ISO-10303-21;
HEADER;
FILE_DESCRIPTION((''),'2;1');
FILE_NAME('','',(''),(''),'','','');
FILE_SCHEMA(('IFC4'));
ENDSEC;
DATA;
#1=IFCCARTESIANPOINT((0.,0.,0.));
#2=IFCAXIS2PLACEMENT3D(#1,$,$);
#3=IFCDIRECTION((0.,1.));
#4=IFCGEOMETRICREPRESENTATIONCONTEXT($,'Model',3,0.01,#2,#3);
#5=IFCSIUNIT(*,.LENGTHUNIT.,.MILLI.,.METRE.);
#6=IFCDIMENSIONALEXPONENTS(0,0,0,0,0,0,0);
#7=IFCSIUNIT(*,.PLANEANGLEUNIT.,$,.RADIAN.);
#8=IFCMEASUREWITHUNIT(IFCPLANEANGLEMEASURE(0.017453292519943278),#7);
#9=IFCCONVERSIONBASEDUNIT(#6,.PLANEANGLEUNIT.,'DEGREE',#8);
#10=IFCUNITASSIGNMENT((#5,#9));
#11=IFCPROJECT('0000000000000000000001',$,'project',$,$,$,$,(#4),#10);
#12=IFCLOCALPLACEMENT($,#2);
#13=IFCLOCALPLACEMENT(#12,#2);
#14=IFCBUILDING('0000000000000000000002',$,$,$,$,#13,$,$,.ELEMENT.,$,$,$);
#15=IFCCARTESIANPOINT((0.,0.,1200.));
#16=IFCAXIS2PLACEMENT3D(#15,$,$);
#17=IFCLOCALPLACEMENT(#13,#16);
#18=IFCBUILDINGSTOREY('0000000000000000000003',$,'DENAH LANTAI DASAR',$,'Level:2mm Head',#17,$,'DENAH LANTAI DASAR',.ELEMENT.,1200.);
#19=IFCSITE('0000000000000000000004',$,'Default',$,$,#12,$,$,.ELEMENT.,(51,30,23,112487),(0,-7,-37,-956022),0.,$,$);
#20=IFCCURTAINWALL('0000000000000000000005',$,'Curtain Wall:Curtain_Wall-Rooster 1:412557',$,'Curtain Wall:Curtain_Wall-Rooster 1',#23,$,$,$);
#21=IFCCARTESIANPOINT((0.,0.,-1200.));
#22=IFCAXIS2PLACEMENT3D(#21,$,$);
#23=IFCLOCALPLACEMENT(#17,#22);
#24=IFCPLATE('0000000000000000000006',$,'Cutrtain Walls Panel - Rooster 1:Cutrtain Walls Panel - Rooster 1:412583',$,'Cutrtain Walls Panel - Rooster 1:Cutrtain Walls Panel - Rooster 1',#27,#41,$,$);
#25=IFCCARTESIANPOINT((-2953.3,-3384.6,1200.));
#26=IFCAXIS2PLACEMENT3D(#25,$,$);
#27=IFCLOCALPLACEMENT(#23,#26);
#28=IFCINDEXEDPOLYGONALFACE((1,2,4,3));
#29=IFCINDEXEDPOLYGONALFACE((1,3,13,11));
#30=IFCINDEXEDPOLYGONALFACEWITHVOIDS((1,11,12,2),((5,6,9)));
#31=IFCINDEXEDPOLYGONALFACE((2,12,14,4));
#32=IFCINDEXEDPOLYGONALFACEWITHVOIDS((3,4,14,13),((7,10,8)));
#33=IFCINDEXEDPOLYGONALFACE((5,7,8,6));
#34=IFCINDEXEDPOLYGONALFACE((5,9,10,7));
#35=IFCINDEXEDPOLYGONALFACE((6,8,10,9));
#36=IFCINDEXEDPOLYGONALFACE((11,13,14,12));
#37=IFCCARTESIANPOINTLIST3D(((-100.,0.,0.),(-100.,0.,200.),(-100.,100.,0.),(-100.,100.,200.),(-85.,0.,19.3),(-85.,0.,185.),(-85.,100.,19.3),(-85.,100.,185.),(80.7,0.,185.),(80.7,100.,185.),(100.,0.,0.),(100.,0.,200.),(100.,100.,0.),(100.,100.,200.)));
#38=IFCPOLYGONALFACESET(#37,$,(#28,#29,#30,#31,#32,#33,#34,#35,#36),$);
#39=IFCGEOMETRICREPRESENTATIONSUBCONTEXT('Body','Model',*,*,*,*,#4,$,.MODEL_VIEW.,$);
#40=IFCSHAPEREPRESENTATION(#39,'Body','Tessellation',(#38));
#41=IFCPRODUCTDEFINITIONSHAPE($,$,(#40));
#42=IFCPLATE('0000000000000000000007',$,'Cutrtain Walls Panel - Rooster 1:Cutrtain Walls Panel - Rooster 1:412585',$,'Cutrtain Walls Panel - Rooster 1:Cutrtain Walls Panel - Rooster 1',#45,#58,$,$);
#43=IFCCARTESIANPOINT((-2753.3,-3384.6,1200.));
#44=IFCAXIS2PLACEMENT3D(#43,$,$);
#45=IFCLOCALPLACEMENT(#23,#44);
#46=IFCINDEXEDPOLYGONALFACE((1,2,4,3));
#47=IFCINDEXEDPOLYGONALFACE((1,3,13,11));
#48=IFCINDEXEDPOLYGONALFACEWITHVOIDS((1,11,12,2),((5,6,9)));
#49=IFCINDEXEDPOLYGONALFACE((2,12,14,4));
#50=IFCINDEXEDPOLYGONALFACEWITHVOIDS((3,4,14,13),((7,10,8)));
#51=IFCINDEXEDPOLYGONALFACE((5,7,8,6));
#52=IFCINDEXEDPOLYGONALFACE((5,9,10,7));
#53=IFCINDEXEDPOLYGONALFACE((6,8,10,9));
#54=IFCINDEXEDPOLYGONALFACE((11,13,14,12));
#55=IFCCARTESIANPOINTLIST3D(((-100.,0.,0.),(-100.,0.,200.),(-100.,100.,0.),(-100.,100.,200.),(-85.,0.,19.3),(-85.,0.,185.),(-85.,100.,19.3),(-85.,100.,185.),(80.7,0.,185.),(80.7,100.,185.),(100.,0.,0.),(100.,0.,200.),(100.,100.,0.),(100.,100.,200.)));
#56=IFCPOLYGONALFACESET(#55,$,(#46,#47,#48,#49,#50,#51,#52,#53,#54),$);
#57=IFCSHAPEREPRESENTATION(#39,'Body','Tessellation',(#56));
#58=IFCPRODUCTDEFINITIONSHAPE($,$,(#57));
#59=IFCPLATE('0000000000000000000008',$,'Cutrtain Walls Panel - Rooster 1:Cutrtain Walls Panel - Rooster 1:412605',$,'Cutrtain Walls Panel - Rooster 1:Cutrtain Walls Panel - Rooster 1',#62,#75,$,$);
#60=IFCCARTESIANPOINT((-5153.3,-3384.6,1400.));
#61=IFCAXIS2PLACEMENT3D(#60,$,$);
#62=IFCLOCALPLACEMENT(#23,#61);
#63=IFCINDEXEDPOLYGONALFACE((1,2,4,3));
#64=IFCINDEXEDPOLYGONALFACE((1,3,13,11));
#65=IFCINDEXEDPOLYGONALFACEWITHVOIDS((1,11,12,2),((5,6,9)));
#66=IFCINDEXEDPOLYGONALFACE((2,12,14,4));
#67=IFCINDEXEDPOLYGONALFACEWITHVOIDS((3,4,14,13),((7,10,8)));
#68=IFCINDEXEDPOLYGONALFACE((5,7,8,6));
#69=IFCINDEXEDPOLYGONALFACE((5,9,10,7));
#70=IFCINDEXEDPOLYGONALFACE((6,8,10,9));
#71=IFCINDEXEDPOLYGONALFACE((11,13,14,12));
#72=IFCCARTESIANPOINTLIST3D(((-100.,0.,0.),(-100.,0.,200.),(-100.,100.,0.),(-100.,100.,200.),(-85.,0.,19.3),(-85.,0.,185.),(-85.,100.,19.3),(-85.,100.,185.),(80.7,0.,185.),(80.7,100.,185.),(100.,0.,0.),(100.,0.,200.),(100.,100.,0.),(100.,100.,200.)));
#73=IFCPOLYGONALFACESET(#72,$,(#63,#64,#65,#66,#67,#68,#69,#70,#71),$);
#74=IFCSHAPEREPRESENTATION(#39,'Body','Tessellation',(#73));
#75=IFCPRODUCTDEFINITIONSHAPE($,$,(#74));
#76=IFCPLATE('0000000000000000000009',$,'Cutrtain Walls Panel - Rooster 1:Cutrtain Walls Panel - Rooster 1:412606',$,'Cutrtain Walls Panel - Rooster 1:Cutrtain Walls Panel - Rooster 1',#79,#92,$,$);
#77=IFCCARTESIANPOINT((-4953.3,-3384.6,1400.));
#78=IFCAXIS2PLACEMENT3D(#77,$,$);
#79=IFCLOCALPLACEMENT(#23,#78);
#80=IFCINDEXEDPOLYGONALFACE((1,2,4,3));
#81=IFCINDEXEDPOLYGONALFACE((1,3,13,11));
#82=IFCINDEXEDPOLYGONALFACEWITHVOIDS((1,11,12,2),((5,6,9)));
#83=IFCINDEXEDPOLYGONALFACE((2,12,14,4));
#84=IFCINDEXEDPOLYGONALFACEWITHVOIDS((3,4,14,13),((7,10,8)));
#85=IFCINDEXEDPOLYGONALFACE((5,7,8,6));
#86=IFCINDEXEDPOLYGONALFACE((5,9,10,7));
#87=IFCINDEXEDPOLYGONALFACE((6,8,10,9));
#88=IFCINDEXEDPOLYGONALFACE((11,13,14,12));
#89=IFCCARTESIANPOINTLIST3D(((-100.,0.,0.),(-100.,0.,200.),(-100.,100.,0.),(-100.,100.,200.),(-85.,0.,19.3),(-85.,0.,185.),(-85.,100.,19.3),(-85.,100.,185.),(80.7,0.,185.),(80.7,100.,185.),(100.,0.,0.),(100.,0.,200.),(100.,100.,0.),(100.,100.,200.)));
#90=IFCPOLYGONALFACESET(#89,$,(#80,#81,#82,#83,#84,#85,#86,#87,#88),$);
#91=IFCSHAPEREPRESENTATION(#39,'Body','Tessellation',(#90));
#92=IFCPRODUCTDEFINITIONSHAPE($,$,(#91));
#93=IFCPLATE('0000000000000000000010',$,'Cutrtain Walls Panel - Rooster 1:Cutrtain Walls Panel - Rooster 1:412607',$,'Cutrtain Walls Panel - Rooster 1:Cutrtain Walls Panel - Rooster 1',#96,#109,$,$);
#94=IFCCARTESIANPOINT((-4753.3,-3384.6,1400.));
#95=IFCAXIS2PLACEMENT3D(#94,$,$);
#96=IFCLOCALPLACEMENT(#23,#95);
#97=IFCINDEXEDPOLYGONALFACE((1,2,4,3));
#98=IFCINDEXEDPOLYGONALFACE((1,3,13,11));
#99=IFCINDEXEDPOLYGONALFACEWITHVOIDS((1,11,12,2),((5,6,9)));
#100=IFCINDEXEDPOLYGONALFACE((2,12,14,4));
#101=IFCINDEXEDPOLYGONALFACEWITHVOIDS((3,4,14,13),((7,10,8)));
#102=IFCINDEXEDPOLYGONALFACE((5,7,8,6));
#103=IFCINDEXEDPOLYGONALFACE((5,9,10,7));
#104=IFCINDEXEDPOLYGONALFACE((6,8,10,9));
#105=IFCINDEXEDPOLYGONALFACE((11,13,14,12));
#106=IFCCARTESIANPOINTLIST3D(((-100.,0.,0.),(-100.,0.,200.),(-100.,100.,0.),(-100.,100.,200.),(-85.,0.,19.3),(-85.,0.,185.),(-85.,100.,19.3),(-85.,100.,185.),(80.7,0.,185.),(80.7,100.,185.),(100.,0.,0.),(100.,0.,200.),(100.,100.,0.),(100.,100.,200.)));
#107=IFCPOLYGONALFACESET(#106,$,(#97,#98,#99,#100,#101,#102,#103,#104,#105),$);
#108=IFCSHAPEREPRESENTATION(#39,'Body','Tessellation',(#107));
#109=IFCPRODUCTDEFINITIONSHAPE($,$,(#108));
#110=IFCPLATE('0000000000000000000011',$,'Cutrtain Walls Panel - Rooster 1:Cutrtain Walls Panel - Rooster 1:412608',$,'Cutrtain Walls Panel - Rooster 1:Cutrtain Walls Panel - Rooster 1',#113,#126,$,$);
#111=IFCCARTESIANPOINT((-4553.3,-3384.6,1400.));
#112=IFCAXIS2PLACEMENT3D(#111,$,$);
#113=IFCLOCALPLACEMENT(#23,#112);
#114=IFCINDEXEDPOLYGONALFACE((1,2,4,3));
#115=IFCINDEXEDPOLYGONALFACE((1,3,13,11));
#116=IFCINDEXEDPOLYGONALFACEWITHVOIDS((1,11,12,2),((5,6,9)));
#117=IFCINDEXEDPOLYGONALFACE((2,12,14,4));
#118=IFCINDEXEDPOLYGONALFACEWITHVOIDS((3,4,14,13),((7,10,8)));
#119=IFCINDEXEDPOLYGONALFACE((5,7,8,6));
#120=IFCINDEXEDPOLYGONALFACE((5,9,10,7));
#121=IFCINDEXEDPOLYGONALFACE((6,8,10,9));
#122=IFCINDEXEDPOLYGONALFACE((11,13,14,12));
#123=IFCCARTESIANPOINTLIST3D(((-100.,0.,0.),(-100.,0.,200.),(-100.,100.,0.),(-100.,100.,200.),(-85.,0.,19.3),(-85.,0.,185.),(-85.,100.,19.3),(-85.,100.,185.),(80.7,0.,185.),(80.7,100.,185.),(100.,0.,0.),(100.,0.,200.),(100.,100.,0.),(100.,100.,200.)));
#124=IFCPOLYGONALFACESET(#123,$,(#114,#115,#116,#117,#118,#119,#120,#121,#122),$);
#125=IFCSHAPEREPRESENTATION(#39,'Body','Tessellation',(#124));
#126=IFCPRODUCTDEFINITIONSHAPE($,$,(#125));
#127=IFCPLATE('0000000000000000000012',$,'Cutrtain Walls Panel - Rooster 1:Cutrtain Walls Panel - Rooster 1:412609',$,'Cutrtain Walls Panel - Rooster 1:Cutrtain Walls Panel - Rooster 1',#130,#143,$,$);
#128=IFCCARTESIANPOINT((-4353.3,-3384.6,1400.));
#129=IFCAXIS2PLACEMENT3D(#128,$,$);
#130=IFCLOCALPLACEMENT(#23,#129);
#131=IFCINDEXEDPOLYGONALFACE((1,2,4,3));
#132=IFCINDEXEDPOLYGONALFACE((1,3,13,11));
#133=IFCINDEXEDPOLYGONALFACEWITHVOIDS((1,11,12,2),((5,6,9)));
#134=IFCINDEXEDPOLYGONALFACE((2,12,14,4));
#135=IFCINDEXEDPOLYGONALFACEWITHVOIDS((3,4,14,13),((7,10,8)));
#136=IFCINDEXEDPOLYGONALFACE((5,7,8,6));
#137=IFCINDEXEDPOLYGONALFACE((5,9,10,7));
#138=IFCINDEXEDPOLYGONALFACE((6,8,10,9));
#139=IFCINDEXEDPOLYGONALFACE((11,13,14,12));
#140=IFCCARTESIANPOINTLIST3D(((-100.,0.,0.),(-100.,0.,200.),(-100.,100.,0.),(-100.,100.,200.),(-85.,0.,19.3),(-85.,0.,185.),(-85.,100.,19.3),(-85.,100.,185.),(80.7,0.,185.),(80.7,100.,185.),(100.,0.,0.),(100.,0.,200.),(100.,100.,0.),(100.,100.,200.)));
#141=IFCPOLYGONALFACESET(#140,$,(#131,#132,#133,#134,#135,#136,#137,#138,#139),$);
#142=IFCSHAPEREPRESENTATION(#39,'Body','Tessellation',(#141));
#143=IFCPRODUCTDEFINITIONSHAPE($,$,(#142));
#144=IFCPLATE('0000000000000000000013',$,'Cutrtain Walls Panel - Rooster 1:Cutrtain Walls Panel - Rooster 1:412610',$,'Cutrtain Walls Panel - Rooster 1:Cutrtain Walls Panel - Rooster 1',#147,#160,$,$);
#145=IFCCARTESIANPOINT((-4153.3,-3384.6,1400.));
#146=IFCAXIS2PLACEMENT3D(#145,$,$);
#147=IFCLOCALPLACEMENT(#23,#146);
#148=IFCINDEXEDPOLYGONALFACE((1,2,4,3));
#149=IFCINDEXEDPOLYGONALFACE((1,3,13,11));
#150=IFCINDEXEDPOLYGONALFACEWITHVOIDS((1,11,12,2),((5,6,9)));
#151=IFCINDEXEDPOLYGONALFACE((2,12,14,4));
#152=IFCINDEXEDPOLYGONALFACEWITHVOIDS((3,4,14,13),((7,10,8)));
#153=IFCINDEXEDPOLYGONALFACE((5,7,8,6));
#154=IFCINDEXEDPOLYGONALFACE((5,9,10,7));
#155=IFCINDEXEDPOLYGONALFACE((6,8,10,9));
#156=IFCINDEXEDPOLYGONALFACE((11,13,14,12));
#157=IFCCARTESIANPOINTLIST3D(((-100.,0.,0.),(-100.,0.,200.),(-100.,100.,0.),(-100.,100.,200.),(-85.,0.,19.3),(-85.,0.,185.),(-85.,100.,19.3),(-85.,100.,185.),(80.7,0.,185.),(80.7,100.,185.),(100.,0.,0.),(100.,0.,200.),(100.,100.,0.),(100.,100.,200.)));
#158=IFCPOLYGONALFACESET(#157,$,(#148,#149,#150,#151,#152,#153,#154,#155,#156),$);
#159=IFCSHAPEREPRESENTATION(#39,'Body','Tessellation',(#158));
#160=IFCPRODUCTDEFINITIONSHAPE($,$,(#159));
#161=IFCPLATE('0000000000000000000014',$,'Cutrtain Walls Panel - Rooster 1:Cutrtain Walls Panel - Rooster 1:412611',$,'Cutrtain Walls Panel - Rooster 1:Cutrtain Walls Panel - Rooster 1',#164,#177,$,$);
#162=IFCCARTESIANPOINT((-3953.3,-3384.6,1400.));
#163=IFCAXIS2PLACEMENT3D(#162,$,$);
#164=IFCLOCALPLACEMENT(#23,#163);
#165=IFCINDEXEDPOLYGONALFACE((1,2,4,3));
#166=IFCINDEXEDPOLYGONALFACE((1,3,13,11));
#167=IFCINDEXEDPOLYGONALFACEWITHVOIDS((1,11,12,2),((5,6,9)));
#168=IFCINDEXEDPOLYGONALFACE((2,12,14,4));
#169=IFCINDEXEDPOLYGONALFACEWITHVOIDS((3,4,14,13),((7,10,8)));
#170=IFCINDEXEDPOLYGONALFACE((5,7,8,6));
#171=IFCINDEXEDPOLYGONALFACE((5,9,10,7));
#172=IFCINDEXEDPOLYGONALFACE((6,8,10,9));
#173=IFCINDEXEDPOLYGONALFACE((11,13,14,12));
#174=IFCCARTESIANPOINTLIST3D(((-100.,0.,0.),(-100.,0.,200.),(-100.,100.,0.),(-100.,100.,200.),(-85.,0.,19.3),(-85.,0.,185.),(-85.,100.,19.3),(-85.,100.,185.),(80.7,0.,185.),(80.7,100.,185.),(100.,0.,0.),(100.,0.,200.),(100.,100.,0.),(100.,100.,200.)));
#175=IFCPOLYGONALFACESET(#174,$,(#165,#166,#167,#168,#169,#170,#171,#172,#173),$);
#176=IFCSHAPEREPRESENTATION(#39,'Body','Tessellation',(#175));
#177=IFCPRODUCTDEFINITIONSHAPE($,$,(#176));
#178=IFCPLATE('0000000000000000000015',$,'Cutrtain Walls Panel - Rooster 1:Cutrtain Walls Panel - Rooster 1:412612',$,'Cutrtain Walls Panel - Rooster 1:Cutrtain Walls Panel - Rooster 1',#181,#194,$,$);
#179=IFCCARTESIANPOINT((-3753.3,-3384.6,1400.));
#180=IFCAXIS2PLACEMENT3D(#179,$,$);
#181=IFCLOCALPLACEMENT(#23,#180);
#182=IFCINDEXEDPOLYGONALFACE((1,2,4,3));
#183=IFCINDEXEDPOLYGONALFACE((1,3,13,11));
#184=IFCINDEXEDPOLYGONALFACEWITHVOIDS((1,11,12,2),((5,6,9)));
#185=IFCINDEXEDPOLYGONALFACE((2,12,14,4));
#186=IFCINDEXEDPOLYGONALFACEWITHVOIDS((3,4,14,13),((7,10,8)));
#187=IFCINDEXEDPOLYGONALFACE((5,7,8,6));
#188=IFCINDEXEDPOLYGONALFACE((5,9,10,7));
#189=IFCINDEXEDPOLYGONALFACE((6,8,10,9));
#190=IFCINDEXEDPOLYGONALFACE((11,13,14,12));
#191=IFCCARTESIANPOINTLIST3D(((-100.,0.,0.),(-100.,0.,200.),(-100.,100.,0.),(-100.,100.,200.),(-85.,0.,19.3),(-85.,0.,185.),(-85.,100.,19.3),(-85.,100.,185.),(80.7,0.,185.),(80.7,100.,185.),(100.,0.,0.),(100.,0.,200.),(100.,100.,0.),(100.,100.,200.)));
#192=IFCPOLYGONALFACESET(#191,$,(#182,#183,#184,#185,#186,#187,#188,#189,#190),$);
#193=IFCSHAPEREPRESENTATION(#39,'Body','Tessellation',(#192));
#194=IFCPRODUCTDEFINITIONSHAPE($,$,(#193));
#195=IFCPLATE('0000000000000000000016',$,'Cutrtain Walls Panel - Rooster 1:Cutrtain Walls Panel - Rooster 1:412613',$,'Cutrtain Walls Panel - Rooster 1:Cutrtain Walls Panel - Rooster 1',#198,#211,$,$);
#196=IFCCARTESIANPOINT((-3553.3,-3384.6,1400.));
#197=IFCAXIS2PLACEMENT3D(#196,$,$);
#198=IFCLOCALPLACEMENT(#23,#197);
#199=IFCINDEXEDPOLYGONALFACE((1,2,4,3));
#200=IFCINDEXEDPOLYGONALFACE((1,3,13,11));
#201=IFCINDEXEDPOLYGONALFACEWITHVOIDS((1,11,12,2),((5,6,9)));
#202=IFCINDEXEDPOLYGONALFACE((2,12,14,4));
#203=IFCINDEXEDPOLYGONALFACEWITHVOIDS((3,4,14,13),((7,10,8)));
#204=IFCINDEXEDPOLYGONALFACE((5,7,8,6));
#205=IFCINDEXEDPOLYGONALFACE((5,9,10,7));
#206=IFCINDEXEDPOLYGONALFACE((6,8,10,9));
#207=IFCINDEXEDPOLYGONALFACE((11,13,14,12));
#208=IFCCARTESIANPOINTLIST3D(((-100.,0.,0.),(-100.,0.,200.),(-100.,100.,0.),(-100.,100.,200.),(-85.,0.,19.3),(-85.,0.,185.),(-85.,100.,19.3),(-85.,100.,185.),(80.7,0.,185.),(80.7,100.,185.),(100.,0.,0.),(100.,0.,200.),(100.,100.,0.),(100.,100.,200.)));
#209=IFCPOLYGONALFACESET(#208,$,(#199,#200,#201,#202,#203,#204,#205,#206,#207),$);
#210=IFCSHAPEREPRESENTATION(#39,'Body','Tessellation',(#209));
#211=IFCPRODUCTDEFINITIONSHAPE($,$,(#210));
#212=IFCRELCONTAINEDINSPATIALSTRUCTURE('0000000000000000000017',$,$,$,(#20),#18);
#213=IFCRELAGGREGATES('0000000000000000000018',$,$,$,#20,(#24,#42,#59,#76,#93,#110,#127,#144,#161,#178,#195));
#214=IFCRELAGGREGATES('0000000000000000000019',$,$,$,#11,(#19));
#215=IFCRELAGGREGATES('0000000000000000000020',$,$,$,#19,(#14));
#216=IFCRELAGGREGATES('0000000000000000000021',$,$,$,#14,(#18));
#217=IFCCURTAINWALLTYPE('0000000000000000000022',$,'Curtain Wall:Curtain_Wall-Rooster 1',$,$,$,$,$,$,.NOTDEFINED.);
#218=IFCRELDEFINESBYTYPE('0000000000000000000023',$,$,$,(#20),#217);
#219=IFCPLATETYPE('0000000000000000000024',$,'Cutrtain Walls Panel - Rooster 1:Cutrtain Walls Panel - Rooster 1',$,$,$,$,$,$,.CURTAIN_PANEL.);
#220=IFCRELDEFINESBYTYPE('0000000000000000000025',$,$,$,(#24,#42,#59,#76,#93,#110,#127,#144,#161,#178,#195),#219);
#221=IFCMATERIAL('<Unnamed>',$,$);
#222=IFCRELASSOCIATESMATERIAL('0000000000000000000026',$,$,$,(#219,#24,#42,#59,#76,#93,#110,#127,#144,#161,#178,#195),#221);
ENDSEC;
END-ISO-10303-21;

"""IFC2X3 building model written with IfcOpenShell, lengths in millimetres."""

from ifc_helpers import new_model, entity, si_unit, converted_unit, direction, frame, origin, place, context, subcontext, project, spatial, polyline, outline, extrude, source, transform, mapped, material, type_object, type_shapes, element, aggregate, save


model = new_model("IFC2X3")

# Units and contexts
model_context = context("Model", 3, precision=0.01, world=origin(), true_north=direction((0.0, 1.0)))
body_context = subcontext(model_context, "Body", "Model", "MODEL_VIEW")
ifc_project = project(units=[si_unit("LENGTHUNIT", "METRE", prefix="MILLI"), converted_unit("PLANEANGLEUNIT", "DEGREE", entity("IfcPlaneAngleMeasure", 0.017453292519943278), si_unit("PLANEANGLEUNIT", "RADIAN"), dimensions=[0, 0, 0, 0, 0, 0, 0])], contexts=[model_context])

# Site, building, storey
site_placement = place(None, origin())
site = spatial("IfcSite", under=ifc_project, at=site_placement, Name="Default", CompositionType="ELEMENT", RefLatitude=(51, 30, 23, 112487), RefLongitude=(0, -7, -37, -956022), RefElevation=0.0)
building_placement = place(site_placement, origin())
building = spatial("IfcBuilding", under=site, at=building_placement, CompositionType="ELEMENT")
storey_placement = place(building_placement, frame((0.0, 0.0, 1200.0)))
storey = spatial("IfcBuildingStorey", under=building, at=storey_placement, Name="DENAH LANTAI DASAR", ObjectType="Level:2mm Head", LongName="DENAH LANTAI DASAR", CompositionType="ELEMENT", Elevation=1200.0)

# Curtain wall, plates
curtain_wall_type = type_object("IfcCurtainWallType", Name="Curtain Wall:Curtain_Wall-Rooster 1", PredefinedType="NOTDEFINED")
curtain_wall_placement = place(storey_placement, frame((0.0, 0.0, -1200.0)))
curtain_wall = element("IfcCurtainWall", 1, at=curtain_wall_placement, inside=storey, type_object=curtain_wall_type, Name="Curtain Wall:Curtain_Wall-Rooster 1:412557", ObjectType="Curtain Wall:Curtain_Wall-Rooster 1")
ifc_material = material(Name="<Unnamed>")
plate_type = type_object("IfcPlateType", Name="Cutrtain Walls Panel - Rooster 1:Cutrtain Walls Panel - Rooster 1", PredefinedType="CURTAIN_PANEL", material=ifc_material)
shared_shape = source(origin(), body_context, "Body", "SweptSolid", [
    extrude(outline(polyline([(-100.0, -100.0), (100.0, -100.0), (100.0, 100.0), (-100.0, 100.0), (-100.0, -100.0)]), holes=[polyline([(80.7, 85.0), (-85.0, -80.7), (-85.0, 85.0), (80.7, 85.0)])]), frame((0.0, 0.0, 100.0), z_axis=(0.0, 1.0, 0.0), x_axis=(0.0, 0.0, -1.0)), (0.0, 0.0, 1.0), 100.0),
])
type_shapes(plate_type, [shared_shape])
plate_1_placement = place(curtain_wall_placement, frame((-2953.3, -3384.6, 1200.0)))
plate_1 = element("IfcPlate", 2, at=plate_1_placement, type_object=plate_type, material=ifc_material, Name="Cutrtain Walls Panel - Rooster 1:Cutrtain Walls Panel - Rooster 1:412583", ObjectType="Cutrtain Walls Panel - Rooster 1:Cutrtain Walls Panel - Rooster 1", context=body_context, shape_type="MappedRepresentation", body=[
    mapped(shared_shape, transform((0.0, 0.0, 0.0), scale=1.0)),
])
plate_2_placement = place(curtain_wall_placement, frame((-2753.3, -3384.6, 1200.0)))
plate_2 = element("IfcPlate", 3, at=plate_2_placement, type_object=plate_type, material=ifc_material, Name="Cutrtain Walls Panel - Rooster 1:Cutrtain Walls Panel - Rooster 1:412585", ObjectType="Cutrtain Walls Panel - Rooster 1:Cutrtain Walls Panel - Rooster 1", context=body_context, shape_type="MappedRepresentation", body=[
    mapped(shared_shape, transform((0.0, 0.0, 0.0), scale=1.0)),
])
plate_3_placement = place(curtain_wall_placement, frame((-5153.3, -3384.6, 1400.0)))
plate_3 = element("IfcPlate", 4, at=plate_3_placement, type_object=plate_type, material=ifc_material, Name="Cutrtain Walls Panel - Rooster 1:Cutrtain Walls Panel - Rooster 1:412605", ObjectType="Cutrtain Walls Panel - Rooster 1:Cutrtain Walls Panel - Rooster 1", context=body_context, shape_type="MappedRepresentation", body=[
    mapped(shared_shape, transform((0.0, 0.0, 0.0), scale=1.0)),
])
plate_4_placement = place(curtain_wall_placement, frame((-4953.3, -3384.6, 1400.0)))
plate_4 = element("IfcPlate", 5, at=plate_4_placement, type_object=plate_type, material=ifc_material, Name="Cutrtain Walls Panel - Rooster 1:Cutrtain Walls Panel - Rooster 1:412606", ObjectType="Cutrtain Walls Panel - Rooster 1:Cutrtain Walls Panel - Rooster 1", context=body_context, shape_type="MappedRepresentation", body=[
    mapped(shared_shape, transform((0.0, 0.0, 0.0), scale=1.0)),
])
plate_5_placement = place(curtain_wall_placement, frame((-4753.3, -3384.6, 1400.0)))
plate_5 = element("IfcPlate", 6, at=plate_5_placement, type_object=plate_type, material=ifc_material, Name="Cutrtain Walls Panel - Rooster 1:Cutrtain Walls Panel - Rooster 1:412607", ObjectType="Cutrtain Walls Panel - Rooster 1:Cutrtain Walls Panel - Rooster 1", context=body_context, shape_type="MappedRepresentation", body=[
    mapped(shared_shape, transform((0.0, 0.0, 0.0), scale=1.0)),
])
plate_6_placement = place(curtain_wall_placement, frame((-4553.3, -3384.6, 1400.0)))
plate_6 = element("IfcPlate", 7, at=plate_6_placement, type_object=plate_type, material=ifc_material, Name="Cutrtain Walls Panel - Rooster 1:Cutrtain Walls Panel - Rooster 1:412608", ObjectType="Cutrtain Walls Panel - Rooster 1:Cutrtain Walls Panel - Rooster 1", context=body_context, shape_type="MappedRepresentation", body=[
    mapped(shared_shape, transform((0.0, 0.0, 0.0), scale=1.0)),
])
plate_7_placement = place(curtain_wall_placement, frame((-4353.3, -3384.6, 1400.0)))
plate_7 = element("IfcPlate", 8, at=plate_7_placement, type_object=plate_type, material=ifc_material, Name="Cutrtain Walls Panel - Rooster 1:Cutrtain Walls Panel - Rooster 1:412609", ObjectType="Cutrtain Walls Panel - Rooster 1:Cutrtain Walls Panel - Rooster 1", context=body_context, shape_type="MappedRepresentation", body=[
    mapped(shared_shape, transform((0.0, 0.0, 0.0), scale=1.0)),
])
plate_8_placement = place(curtain_wall_placement, frame((-4153.3, -3384.6, 1400.0)))
plate_8 = element("IfcPlate", 9, at=plate_8_placement, type_object=plate_type, material=ifc_material, Name="Cutrtain Walls Panel - Rooster 1:Cutrtain Walls Panel - Rooster 1:412610", ObjectType="Cutrtain Walls Panel - Rooster 1:Cutrtain Walls Panel - Rooster 1", context=body_context, shape_type="MappedRepresentation", body=[
    mapped(shared_shape, transform((0.0, 0.0, 0.0), scale=1.0)),
])
plate_9_placement = place(curtain_wall_placement, frame((-3953.3, -3384.6, 1400.0)))
plate_9 = element("IfcPlate", 10, at=plate_9_placement, type_object=plate_type, material=ifc_material, Name="Cutrtain Walls Panel - Rooster 1:Cutrtain Walls Panel - Rooster 1:412611", ObjectType="Cutrtain Walls Panel - Rooster 1:Cutrtain Walls Panel - Rooster 1", context=body_context, shape_type="MappedRepresentation", body=[
    mapped(shared_shape, transform((0.0, 0.0, 0.0), scale=1.0)),
])
plate_10_placement = place(curtain_wall_placement, frame((-3753.3, -3384.6, 1400.0)))
plate_10 = element("IfcPlate", 11, at=plate_10_placement, type_object=plate_type, material=ifc_material, Name="Cutrtain Walls Panel - Rooster 1:Cutrtain Walls Panel - Rooster 1:412612", ObjectType="Cutrtain Walls Panel - Rooster 1:Cutrtain Walls Panel - Rooster 1", context=body_context, shape_type="MappedRepresentation", body=[
    mapped(shared_shape, transform((0.0, 0.0, 0.0), scale=1.0)),
])
plate_11_placement = place(curtain_wall_placement, frame((-3553.3, -3384.6, 1400.0)))
plate_11 = element("IfcPlate", 12, at=plate_11_placement, type_object=plate_type, material=ifc_material, Name="Cutrtain Walls Panel - Rooster 1:Cutrtain Walls Panel - Rooster 1:412613", ObjectType="Cutrtain Walls Panel - Rooster 1:Cutrtain Walls Panel - Rooster 1", context=body_context, shape_type="MappedRepresentation", body=[
    mapped(shared_shape, transform((0.0, 0.0, 0.0), scale=1.0)),
])
aggregate(curtain_wall, [plate_1, plate_2, plate_3, plate_4, plate_5, plate_6, plate_7, plate_8, plate_9, plate_10, plate_11])

save(model, "model.ifc")
